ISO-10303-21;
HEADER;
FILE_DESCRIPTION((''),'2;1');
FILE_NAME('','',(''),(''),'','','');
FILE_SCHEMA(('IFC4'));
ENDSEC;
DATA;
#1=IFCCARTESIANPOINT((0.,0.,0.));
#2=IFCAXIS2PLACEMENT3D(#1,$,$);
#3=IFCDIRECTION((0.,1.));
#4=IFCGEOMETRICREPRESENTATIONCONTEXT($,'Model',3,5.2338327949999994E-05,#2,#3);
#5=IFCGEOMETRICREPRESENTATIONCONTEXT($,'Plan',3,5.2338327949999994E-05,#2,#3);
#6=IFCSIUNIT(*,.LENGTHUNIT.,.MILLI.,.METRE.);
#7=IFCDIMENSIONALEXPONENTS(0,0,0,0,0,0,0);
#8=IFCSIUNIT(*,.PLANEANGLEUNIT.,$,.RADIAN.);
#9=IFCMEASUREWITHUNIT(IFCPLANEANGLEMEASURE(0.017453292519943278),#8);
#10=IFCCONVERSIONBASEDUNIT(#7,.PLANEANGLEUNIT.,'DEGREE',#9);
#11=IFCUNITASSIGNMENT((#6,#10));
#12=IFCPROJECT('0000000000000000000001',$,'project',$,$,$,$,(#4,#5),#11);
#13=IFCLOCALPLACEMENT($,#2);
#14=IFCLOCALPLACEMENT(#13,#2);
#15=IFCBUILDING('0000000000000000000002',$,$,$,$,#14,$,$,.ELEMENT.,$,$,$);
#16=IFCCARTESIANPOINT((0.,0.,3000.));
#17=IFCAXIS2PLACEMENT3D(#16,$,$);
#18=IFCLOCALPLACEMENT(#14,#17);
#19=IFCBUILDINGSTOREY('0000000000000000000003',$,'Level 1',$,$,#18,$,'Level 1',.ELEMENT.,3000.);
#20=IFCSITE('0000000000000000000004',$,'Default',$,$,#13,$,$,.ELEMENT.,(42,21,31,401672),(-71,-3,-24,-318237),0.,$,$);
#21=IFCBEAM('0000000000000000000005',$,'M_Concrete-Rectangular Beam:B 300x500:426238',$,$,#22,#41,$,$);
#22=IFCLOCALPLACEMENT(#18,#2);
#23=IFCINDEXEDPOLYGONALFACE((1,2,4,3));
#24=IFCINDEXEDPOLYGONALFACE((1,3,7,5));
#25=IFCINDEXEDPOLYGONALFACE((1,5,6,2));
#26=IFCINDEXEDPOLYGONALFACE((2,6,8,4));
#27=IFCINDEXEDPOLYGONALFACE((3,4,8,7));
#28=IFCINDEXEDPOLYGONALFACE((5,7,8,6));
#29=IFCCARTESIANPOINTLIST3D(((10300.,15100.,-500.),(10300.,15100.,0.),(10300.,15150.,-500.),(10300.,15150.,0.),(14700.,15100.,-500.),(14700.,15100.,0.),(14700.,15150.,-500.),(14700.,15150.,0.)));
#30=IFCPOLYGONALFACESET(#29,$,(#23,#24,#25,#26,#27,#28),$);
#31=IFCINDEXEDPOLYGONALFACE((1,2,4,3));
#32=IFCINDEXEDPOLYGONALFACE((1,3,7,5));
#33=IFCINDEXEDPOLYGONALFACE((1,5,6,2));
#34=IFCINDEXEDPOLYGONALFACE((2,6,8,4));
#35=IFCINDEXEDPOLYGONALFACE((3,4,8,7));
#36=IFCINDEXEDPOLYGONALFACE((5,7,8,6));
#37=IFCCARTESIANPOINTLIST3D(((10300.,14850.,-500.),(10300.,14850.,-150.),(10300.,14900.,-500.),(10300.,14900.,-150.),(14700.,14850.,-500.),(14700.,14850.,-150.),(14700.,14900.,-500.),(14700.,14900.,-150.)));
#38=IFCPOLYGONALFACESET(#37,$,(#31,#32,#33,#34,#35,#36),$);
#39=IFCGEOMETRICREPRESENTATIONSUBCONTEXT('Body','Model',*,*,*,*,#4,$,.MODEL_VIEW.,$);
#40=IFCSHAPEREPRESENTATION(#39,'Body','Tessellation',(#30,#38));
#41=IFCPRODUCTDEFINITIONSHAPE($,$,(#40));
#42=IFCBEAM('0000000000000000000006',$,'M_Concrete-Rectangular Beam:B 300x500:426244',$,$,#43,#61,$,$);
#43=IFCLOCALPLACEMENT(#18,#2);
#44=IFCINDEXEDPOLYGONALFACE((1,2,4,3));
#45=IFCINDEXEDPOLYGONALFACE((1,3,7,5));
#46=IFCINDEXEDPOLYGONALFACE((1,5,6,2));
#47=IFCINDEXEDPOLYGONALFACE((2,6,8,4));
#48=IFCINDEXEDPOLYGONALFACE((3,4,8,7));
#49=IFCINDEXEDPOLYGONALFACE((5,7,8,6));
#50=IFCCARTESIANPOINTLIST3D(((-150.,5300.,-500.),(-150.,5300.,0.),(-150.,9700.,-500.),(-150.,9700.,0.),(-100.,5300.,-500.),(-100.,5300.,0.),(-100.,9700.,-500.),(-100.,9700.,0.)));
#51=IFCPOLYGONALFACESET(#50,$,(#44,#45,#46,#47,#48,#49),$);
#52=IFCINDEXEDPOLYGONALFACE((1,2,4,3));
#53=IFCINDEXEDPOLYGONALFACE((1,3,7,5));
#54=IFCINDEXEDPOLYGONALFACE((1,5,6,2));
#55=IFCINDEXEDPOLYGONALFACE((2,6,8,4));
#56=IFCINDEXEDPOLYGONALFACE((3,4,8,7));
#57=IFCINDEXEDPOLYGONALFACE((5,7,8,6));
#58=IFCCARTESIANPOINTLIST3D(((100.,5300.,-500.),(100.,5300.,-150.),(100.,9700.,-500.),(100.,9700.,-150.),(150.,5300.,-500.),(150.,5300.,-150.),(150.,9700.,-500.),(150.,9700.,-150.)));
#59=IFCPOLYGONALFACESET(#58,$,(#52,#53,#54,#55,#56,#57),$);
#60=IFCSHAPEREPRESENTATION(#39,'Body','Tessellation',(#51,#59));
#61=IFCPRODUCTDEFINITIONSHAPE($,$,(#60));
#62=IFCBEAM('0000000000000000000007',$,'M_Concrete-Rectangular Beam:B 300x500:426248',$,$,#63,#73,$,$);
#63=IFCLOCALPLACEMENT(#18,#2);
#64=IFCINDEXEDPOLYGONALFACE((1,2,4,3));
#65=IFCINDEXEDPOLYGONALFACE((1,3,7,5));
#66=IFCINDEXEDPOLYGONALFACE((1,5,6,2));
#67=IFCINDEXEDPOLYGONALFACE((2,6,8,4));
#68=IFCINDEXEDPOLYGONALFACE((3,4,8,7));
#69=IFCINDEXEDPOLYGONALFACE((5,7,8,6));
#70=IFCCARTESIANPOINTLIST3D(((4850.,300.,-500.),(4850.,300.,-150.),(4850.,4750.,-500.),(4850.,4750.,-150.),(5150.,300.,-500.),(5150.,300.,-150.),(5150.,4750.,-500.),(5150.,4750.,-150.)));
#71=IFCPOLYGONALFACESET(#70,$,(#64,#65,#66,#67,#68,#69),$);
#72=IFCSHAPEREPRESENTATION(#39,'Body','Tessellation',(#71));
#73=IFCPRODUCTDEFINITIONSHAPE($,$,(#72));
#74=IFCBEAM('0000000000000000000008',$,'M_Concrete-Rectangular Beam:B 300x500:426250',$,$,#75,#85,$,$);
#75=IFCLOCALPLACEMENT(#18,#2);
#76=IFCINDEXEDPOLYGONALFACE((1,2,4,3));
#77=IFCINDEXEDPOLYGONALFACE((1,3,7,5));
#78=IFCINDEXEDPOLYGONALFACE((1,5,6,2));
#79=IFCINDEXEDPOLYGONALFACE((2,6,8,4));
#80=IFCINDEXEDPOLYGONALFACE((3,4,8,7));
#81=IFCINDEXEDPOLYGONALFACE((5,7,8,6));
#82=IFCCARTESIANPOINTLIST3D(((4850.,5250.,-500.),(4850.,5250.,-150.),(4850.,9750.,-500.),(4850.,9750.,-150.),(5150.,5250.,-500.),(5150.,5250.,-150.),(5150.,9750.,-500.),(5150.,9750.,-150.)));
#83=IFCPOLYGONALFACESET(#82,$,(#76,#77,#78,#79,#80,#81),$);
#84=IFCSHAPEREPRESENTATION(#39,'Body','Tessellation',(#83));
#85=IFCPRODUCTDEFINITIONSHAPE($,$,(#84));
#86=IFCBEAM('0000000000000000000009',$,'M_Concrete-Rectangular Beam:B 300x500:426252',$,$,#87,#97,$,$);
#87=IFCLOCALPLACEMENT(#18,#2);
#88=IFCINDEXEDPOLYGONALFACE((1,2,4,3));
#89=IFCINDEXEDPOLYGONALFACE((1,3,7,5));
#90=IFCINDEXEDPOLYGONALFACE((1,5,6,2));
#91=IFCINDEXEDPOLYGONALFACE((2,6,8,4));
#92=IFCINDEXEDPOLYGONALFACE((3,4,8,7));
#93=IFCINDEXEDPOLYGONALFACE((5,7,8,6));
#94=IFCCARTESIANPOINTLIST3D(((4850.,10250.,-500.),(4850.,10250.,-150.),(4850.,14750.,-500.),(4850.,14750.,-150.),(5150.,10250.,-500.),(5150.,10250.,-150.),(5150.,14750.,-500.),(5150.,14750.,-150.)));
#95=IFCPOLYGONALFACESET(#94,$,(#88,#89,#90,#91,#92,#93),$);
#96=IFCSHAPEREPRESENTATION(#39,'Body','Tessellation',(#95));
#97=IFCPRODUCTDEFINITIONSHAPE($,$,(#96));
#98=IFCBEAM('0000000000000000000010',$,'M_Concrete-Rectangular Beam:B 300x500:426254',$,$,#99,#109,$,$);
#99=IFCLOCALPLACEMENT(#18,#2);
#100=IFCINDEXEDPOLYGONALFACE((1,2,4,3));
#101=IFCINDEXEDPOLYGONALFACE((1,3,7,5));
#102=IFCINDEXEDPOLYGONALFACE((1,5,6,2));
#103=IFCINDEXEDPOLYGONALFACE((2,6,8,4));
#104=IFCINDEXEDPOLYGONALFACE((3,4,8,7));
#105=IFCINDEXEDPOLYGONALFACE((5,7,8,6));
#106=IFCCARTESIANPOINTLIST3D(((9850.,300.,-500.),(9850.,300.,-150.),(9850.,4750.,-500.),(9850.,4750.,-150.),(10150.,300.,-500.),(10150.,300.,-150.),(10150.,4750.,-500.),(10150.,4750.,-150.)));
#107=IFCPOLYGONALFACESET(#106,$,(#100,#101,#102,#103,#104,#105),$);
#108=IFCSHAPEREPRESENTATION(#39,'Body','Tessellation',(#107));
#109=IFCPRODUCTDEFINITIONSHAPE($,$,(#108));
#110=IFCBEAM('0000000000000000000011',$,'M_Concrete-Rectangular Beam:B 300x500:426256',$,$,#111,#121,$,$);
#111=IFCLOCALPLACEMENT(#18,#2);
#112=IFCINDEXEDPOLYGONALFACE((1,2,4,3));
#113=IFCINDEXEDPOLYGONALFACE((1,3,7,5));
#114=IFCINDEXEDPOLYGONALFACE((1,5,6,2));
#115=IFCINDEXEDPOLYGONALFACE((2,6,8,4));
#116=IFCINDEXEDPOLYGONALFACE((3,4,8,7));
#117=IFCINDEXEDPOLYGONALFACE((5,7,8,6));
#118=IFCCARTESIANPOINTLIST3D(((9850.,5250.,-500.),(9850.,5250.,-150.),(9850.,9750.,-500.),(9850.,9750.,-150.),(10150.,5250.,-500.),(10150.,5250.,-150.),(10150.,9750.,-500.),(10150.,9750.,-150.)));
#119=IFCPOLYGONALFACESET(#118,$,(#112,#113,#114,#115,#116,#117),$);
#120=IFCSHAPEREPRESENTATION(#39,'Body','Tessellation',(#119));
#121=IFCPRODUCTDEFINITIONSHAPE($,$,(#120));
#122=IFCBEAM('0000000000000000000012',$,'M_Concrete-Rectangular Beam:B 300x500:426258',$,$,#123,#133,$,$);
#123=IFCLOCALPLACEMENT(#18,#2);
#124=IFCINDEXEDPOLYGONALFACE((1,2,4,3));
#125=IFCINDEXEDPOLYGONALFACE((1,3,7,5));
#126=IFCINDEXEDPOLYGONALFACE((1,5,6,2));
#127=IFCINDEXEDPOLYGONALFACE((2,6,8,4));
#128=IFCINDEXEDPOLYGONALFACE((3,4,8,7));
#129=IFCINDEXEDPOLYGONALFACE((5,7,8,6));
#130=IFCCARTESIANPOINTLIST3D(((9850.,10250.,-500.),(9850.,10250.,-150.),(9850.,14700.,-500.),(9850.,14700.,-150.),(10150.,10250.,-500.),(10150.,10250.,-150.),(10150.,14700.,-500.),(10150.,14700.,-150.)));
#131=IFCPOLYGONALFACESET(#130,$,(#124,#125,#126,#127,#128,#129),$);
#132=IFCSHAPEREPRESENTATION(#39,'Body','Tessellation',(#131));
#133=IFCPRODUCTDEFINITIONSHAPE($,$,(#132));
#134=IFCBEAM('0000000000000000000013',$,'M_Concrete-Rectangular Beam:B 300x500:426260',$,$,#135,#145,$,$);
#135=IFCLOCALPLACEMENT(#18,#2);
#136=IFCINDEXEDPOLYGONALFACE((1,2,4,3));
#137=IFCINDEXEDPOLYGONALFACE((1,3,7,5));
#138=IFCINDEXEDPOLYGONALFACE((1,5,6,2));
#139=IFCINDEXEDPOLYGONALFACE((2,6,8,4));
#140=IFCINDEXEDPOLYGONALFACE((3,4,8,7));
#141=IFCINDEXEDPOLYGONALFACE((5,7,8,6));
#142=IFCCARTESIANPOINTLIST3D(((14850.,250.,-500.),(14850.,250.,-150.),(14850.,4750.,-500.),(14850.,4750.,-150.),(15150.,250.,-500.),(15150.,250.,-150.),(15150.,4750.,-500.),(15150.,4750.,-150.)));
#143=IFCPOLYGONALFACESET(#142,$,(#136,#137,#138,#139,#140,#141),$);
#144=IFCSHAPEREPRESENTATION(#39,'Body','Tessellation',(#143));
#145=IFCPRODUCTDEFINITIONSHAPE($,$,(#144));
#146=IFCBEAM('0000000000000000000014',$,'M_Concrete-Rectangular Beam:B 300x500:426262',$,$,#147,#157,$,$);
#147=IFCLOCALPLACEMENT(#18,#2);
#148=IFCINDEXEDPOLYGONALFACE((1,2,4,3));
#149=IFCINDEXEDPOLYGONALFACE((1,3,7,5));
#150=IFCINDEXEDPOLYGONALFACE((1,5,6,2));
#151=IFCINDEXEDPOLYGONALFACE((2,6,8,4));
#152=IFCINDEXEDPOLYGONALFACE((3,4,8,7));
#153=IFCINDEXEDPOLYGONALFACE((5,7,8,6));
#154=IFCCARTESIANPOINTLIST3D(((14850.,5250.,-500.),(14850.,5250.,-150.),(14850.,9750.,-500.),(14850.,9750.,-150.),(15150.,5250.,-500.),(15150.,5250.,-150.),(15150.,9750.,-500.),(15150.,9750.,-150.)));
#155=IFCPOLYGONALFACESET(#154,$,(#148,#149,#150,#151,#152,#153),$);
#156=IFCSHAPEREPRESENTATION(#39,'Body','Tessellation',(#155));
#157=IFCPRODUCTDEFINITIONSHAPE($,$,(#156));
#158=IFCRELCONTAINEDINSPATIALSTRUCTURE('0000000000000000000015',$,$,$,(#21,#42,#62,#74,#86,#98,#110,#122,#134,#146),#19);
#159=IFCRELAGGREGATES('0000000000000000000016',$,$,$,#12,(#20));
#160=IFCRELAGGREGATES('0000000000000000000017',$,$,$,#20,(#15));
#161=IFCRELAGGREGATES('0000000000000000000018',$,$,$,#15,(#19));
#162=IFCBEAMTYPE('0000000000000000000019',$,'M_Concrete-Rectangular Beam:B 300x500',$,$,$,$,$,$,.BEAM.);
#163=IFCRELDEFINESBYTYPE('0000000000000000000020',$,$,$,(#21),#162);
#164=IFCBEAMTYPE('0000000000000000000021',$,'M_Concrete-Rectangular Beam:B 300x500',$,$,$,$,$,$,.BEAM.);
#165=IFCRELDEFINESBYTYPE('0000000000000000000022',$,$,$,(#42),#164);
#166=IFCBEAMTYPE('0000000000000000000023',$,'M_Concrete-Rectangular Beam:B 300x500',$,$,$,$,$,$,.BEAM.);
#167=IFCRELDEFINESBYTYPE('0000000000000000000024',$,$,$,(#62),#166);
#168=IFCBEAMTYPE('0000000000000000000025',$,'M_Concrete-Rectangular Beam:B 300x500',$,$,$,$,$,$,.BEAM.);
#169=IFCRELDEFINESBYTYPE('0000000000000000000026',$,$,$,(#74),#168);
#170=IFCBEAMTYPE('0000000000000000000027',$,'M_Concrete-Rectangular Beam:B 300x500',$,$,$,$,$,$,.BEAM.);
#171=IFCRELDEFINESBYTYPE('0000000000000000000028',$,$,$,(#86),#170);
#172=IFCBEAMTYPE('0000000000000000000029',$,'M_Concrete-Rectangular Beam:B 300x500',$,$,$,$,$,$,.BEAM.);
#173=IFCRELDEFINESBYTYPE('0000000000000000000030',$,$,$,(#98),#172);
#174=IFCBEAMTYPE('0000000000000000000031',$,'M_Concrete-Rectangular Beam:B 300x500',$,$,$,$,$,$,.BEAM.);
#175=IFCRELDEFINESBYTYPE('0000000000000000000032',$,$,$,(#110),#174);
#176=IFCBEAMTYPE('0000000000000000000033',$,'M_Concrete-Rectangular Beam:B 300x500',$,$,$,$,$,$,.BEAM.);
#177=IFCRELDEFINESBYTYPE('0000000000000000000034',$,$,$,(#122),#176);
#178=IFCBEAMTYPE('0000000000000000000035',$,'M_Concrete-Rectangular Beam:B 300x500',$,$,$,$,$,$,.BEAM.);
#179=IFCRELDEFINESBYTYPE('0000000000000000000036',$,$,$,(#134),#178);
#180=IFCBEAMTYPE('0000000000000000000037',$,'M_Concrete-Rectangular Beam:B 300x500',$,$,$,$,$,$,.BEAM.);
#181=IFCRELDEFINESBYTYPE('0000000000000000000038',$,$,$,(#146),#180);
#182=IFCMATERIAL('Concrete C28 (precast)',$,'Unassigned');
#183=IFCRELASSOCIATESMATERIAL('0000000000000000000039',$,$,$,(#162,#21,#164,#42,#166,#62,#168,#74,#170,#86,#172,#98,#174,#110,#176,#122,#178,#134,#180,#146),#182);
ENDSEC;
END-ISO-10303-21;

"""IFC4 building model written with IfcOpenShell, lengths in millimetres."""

from ifc_helpers import new_model, entity, si_unit, converted_unit, direction, frame, origin, place, context, subcontext, project, spatial, indexed_curve, outline, extrude, source, transform, mapped, material, type_object, type_shapes, element, save


model = new_model("IFC4")

# Units and contexts
model_context = context("Model", 3, precision=5.2338327949999994e-05, world=origin(), true_north=direction((0.0, 1.0)))
plan_context = context("Plan", 3, precision=5.2338327949999994e-05, world=origin(), true_north=direction((0.0, 1.0)))
body_context = subcontext(model_context, "Body", "Model", "MODEL_VIEW")
ifc_project = project(units=[si_unit("LENGTHUNIT", "METRE", prefix="MILLI"), converted_unit("PLANEANGLEUNIT", "DEGREE", entity("IfcPlaneAngleMeasure", 0.017453292519943278), si_unit("PLANEANGLEUNIT", "RADIAN"), dimensions=[0, 0, 0, 0, 0, 0, 0])], contexts=[model_context, plan_context])

# Site, building, storey
site_placement = place(None, origin())
site = spatial("IfcSite", under=ifc_project, at=site_placement, Name="Default", CompositionType="ELEMENT", RefLatitude=(42, 21, 31, 401672), RefLongitude=(-71, -3, -24, -318237), RefElevation=0.0)
building_placement = place(site_placement, origin())
building = spatial("IfcBuilding", under=site, at=building_placement, CompositionType="ELEMENT")
storey_placement = place(building_placement, frame((0.0, 0.0, 3000.0)))
storey = spatial("IfcBuildingStorey", under=building, at=storey_placement, Name="Level 1", LongName="Level 1", CompositionType="ELEMENT", Elevation=3000.0)

# Beams
ifc_material = material(Name="Concrete C28 (precast)", Category="Unassigned")
beam_type_1 = type_object("IfcBeamType", Name="M_Concrete-Rectangular Beam:B 300x500", PredefinedType="BEAM", material=ifc_material)
shared_shape_1 = source(origin(), body_context, "Body", "SweptSolid", [
    extrude(outline(indexed_curve([(-250.0, -25.0), (250.0, -25.0), (250.0, 25.0), (-250.0, 25.0), (-250.0, -25.0)], self_intersect=False)), frame((10300.0, 15125.0, 2750.0), z_axis=(1.0, 0.0, 0.0), x_axis=(0.0, 0.0, -1.0)), (0.0, 0.0, 1.0), 4400.0),
    extrude(outline(indexed_curve([(-175.0, -25.0), (175.0, -25.0), (175.0, 25.0), (-175.0, 25.0), (-175.0, -25.0)], self_intersect=False)), frame((10300.0, 14875.0, 2675.0), z_axis=(1.0, 0.0, 0.0), x_axis=(0.0, 0.0, -1.0)), (0.0, 0.0, 1.0), 4400.0),
])
type_shapes(beam_type_1, [shared_shape_1])
beam_1_placement = place(storey_placement, frame((0.0, 0.0, -3000.0)))
element("IfcBeam", 1, at=beam_1_placement, inside=storey, type_object=beam_type_1, material=ifc_material, Name="M_Concrete-Rectangular Beam:B 300x500:426238", context=body_context, shape_type="MappedRepresentation", body=[
    mapped(shared_shape_1, transform((0.0, 0.0, 0.0), scale=1.0)),
])
beam_type_2 = type_object("IfcBeamType", Name="M_Concrete-Rectangular Beam:B 300x500", PredefinedType="BEAM", material=ifc_material)
shared_shape_2 = source(origin(), body_context, "Body", "SweptSolid", [
    extrude(outline(indexed_curve([(-25.0, -250.0), (25.0, -250.0), (25.0, 250.0), (-25.0, 250.0), (-25.0, -250.0)], self_intersect=False)), frame((-125.0, 5300.0, 2750.0), z_axis=(0.0, 1.0, 0.0), x_axis=(-1.0, 0.0, 0.0)), (0.0, 0.0, 1.0), 4400.0),
    extrude(outline(indexed_curve([(-25.0, -175.0), (25.0, -175.0), (25.0, 175.0), (-25.0, 175.0), (-25.0, -175.0)], self_intersect=False)), frame((125.0, 5300.0, 2675.0), z_axis=(0.0, 1.0, 0.0), x_axis=(-1.0, 0.0, 0.0)), (0.0, 0.0, 1.0), 4400.0),
])
type_shapes(beam_type_2, [shared_shape_2])
beam_2_placement = place(storey_placement, frame((0.0, 0.0, -3000.0)))
element("IfcBeam", 2, at=beam_2_placement, inside=storey, type_object=beam_type_2, material=ifc_material, Name="M_Concrete-Rectangular Beam:B 300x500:426244", context=body_context, shape_type="MappedRepresentation", body=[
    mapped(shared_shape_2, transform((0.0, 0.0, 0.0), scale=1.0)),
])
beam_type_3 = type_object("IfcBeamType", Name="M_Concrete-Rectangular Beam:B 300x500", PredefinedType="BEAM", material=ifc_material)
shared_shape_3 = source(origin(), body_context, "Body", "SweptSolid", [
    extrude(outline(indexed_curve([(-150.0, -175.0), (150.0, -175.0), (150.0, 175.0), (-150.0, 175.0), (-150.0, -175.0)], self_intersect=False)), frame((5000.0, 300.0, 2675.0), z_axis=(0.0, 1.0, 0.0), x_axis=(-1.0, 0.0, 0.0)), (0.0, 0.0, 1.0), 4450.0),
])
type_shapes(beam_type_3, [shared_shape_3])
beam_3_placement = place(storey_placement, frame((0.0, 0.0, -3000.0)))
element("IfcBeam", 3, at=beam_3_placement, inside=storey, type_object=beam_type_3, material=ifc_material, Name="M_Concrete-Rectangular Beam:B 300x500:426248", context=body_context, shape_type="MappedRepresentation", body=[
    mapped(shared_shape_3, transform((0.0, 0.0, 0.0), scale=1.0)),
])
beam_type_4 = type_object("IfcBeamType", Name="M_Concrete-Rectangular Beam:B 300x500", PredefinedType="BEAM", material=ifc_material)
shared_shape_4 = source(origin(), body_context, "Body", "SweptSolid", [
    extrude(outline(indexed_curve([(-150.0, -175.0), (150.0, -175.0), (150.0, 175.0), (-150.0, 175.0), (-150.0, -175.0)], self_intersect=False)), frame((5000.0, 5250.0, 2675.0), z_axis=(0.0, 1.0, 0.0), x_axis=(-1.0, 0.0, 0.0)), (0.0, 0.0, 1.0), 4500.0),
])
type_shapes(beam_type_4, [shared_shape_4])
beam_4_placement = place(storey_placement, frame((0.0, 0.0, -3000.0)))
element("IfcBeam", 4, at=beam_4_placement, inside=storey, type_object=beam_type_4, material=ifc_material, Name="M_Concrete-Rectangular Beam:B 300x500:426250", context=body_context, shape_type="MappedRepresentation", body=[
    mapped(shared_shape_4, transform((0.0, 0.0, 0.0), scale=1.0)),
])
beam_type_5 = type_object("IfcBeamType", Name="M_Concrete-Rectangular Beam:B 300x500", PredefinedType="BEAM", material=ifc_material)
shared_shape_5 = source(origin(), body_context, "Body", "SweptSolid", [
    extrude(outline(indexed_curve([(-150.0, -175.0), (150.0, -175.0), (150.0, 175.0), (-150.0, 175.0), (-150.0, -175.0)], self_intersect=False)), frame((5000.0, 10250.0, 2675.0), z_axis=(0.0, 1.0, 0.0), x_axis=(-1.0, 0.0, 0.0)), (0.0, 0.0, 1.0), 4500.0),
])
type_shapes(beam_type_5, [shared_shape_5])
beam_5_placement = place(storey_placement, frame((0.0, 0.0, -3000.0)))
element("IfcBeam", 5, at=beam_5_placement, inside=storey, type_object=beam_type_5, material=ifc_material, Name="M_Concrete-Rectangular Beam:B 300x500:426252", context=body_context, shape_type="MappedRepresentation", body=[
    mapped(shared_shape_5, transform((0.0, 0.0, 0.0), scale=1.0)),
])
beam_type_6 = type_object("IfcBeamType", Name="M_Concrete-Rectangular Beam:B 300x500", PredefinedType="BEAM", material=ifc_material)
shared_shape_6 = source(origin(), body_context, "Body", "SweptSolid", [
    extrude(outline(indexed_curve([(-150.0, -175.0), (150.0, -175.0), (150.0, 175.0), (-150.0, 175.0), (-150.0, -175.0)], self_intersect=False)), frame((10000.0, 300.0, 2675.0), z_axis=(0.0, 1.0, 0.0), x_axis=(-1.0, 0.0, 0.0)), (0.0, 0.0, 1.0), 4450.0),
])
type_shapes(beam_type_6, [shared_shape_6])
beam_6_placement = place(storey_placement, frame((0.0, 0.0, -3000.0)))
element("IfcBeam", 6, at=beam_6_placement, inside=storey, type_object=beam_type_6, material=ifc_material, Name="M_Concrete-Rectangular Beam:B 300x500:426254", context=body_context, shape_type="MappedRepresentation", body=[
    mapped(shared_shape_6, transform((0.0, 0.0, 0.0), scale=1.0)),
])
beam_type_7 = type_object("IfcBeamType", Name="M_Concrete-Rectangular Beam:B 300x500", PredefinedType="BEAM", material=ifc_material)
shared_shape_7 = source(origin(), body_context, "Body", "SweptSolid", [
    extrude(outline(indexed_curve([(-150.0, -175.0), (150.0, -175.0), (150.0, 175.0), (-150.0, 175.0), (-150.0, -175.0)], self_intersect=False)), frame((10000.0, 5250.0, 2675.0), z_axis=(0.0, 1.0, 0.0), x_axis=(-1.0, 0.0, 0.0)), (0.0, 0.0, 1.0), 4500.0),
])
type_shapes(beam_type_7, [shared_shape_7])
beam_7_placement = place(storey_placement, frame((0.0, 0.0, -3000.0)))
element("IfcBeam", 7, at=beam_7_placement, inside=storey, type_object=beam_type_7, material=ifc_material, Name="M_Concrete-Rectangular Beam:B 300x500:426256", context=body_context, shape_type="MappedRepresentation", body=[
    mapped(shared_shape_7, transform((0.0, 0.0, 0.0), scale=1.0)),
])
beam_type_8 = type_object("IfcBeamType", Name="M_Concrete-Rectangular Beam:B 300x500", PredefinedType="BEAM", material=ifc_material)
shared_shape_8 = source(origin(), body_context, "Body", "SweptSolid", [
    extrude(outline(indexed_curve([(-150.0, -175.0), (150.0, -175.0), (150.0, 175.0), (-150.0, 175.0), (-150.0, -175.0)], self_intersect=False)), frame((10000.0, 10250.0, 2675.0), z_axis=(0.0, 1.0, 0.0), x_axis=(-1.0, 0.0, 0.0)), (0.0, 0.0, 1.0), 4450.0),
])
type_shapes(beam_type_8, [shared_shape_8])
beam_8_placement = place(storey_placement, frame((0.0, 0.0, -3000.0)))
element("IfcBeam", 8, at=beam_8_placement, inside=storey, type_object=beam_type_8, material=ifc_material, Name="M_Concrete-Rectangular Beam:B 300x500:426258", context=body_context, shape_type="MappedRepresentation", body=[
    mapped(shared_shape_8, transform((0.0, 0.0, 0.0), scale=1.0)),
])
beam_type_9 = type_object("IfcBeamType", Name="M_Concrete-Rectangular Beam:B 300x500", PredefinedType="BEAM", material=ifc_material)
shared_shape_9 = source(origin(), body_context, "Body", "SweptSolid", [
    extrude(outline(indexed_curve([(-150.0, -175.0), (150.0, -175.0), (150.0, 175.0), (-150.0, 175.0), (-150.0, -175.0)], self_intersect=False)), frame((15000.0, 250.0, 2675.0), z_axis=(0.0, 1.0, 0.0), x_axis=(-1.0, 0.0, 0.0)), (0.0, 0.0, 1.0), 4500.0),
])
type_shapes(beam_type_9, [shared_shape_9])
beam_9_placement = place(storey_placement, frame((0.0, 0.0, -3000.0)))
element("IfcBeam", 9, at=beam_9_placement, inside=storey, type_object=beam_type_9, material=ifc_material, Name="M_Concrete-Rectangular Beam:B 300x500:426260", context=body_context, shape_type="MappedRepresentation", body=[
    mapped(shared_shape_9, transform((0.0, 0.0, 0.0), scale=1.0)),
])
beam_type_10 = type_object("IfcBeamType", Name="M_Concrete-Rectangular Beam:B 300x500", PredefinedType="BEAM", material=ifc_material)
shared_shape_10 = source(origin(), body_context, "Body", "SweptSolid", [
    extrude(outline(indexed_curve([(-150.0, -175.0), (150.0, -175.0), (150.0, 175.0), (-150.0, 175.0), (-150.0, -175.0)], self_intersect=False)), frame((15000.0, 5250.0, 2675.0), z_axis=(0.0, 1.0, 0.0), x_axis=(-1.0, 0.0, 0.0)), (0.0, 0.0, 1.0), 4500.0),
])
type_shapes(beam_type_10, [shared_shape_10])
beam_10_placement = place(storey_placement, frame((0.0, 0.0, -3000.0)))
element("IfcBeam", 10, at=beam_10_placement, inside=storey, type_object=beam_type_10, material=ifc_material, Name="M_Concrete-Rectangular Beam:B 300x500:426262", context=body_context, shape_type="MappedRepresentation", body=[
    mapped(shared_shape_10, transform((0.0, 0.0, 0.0), scale=1.0)),
])

save(model, "model.ifc")
